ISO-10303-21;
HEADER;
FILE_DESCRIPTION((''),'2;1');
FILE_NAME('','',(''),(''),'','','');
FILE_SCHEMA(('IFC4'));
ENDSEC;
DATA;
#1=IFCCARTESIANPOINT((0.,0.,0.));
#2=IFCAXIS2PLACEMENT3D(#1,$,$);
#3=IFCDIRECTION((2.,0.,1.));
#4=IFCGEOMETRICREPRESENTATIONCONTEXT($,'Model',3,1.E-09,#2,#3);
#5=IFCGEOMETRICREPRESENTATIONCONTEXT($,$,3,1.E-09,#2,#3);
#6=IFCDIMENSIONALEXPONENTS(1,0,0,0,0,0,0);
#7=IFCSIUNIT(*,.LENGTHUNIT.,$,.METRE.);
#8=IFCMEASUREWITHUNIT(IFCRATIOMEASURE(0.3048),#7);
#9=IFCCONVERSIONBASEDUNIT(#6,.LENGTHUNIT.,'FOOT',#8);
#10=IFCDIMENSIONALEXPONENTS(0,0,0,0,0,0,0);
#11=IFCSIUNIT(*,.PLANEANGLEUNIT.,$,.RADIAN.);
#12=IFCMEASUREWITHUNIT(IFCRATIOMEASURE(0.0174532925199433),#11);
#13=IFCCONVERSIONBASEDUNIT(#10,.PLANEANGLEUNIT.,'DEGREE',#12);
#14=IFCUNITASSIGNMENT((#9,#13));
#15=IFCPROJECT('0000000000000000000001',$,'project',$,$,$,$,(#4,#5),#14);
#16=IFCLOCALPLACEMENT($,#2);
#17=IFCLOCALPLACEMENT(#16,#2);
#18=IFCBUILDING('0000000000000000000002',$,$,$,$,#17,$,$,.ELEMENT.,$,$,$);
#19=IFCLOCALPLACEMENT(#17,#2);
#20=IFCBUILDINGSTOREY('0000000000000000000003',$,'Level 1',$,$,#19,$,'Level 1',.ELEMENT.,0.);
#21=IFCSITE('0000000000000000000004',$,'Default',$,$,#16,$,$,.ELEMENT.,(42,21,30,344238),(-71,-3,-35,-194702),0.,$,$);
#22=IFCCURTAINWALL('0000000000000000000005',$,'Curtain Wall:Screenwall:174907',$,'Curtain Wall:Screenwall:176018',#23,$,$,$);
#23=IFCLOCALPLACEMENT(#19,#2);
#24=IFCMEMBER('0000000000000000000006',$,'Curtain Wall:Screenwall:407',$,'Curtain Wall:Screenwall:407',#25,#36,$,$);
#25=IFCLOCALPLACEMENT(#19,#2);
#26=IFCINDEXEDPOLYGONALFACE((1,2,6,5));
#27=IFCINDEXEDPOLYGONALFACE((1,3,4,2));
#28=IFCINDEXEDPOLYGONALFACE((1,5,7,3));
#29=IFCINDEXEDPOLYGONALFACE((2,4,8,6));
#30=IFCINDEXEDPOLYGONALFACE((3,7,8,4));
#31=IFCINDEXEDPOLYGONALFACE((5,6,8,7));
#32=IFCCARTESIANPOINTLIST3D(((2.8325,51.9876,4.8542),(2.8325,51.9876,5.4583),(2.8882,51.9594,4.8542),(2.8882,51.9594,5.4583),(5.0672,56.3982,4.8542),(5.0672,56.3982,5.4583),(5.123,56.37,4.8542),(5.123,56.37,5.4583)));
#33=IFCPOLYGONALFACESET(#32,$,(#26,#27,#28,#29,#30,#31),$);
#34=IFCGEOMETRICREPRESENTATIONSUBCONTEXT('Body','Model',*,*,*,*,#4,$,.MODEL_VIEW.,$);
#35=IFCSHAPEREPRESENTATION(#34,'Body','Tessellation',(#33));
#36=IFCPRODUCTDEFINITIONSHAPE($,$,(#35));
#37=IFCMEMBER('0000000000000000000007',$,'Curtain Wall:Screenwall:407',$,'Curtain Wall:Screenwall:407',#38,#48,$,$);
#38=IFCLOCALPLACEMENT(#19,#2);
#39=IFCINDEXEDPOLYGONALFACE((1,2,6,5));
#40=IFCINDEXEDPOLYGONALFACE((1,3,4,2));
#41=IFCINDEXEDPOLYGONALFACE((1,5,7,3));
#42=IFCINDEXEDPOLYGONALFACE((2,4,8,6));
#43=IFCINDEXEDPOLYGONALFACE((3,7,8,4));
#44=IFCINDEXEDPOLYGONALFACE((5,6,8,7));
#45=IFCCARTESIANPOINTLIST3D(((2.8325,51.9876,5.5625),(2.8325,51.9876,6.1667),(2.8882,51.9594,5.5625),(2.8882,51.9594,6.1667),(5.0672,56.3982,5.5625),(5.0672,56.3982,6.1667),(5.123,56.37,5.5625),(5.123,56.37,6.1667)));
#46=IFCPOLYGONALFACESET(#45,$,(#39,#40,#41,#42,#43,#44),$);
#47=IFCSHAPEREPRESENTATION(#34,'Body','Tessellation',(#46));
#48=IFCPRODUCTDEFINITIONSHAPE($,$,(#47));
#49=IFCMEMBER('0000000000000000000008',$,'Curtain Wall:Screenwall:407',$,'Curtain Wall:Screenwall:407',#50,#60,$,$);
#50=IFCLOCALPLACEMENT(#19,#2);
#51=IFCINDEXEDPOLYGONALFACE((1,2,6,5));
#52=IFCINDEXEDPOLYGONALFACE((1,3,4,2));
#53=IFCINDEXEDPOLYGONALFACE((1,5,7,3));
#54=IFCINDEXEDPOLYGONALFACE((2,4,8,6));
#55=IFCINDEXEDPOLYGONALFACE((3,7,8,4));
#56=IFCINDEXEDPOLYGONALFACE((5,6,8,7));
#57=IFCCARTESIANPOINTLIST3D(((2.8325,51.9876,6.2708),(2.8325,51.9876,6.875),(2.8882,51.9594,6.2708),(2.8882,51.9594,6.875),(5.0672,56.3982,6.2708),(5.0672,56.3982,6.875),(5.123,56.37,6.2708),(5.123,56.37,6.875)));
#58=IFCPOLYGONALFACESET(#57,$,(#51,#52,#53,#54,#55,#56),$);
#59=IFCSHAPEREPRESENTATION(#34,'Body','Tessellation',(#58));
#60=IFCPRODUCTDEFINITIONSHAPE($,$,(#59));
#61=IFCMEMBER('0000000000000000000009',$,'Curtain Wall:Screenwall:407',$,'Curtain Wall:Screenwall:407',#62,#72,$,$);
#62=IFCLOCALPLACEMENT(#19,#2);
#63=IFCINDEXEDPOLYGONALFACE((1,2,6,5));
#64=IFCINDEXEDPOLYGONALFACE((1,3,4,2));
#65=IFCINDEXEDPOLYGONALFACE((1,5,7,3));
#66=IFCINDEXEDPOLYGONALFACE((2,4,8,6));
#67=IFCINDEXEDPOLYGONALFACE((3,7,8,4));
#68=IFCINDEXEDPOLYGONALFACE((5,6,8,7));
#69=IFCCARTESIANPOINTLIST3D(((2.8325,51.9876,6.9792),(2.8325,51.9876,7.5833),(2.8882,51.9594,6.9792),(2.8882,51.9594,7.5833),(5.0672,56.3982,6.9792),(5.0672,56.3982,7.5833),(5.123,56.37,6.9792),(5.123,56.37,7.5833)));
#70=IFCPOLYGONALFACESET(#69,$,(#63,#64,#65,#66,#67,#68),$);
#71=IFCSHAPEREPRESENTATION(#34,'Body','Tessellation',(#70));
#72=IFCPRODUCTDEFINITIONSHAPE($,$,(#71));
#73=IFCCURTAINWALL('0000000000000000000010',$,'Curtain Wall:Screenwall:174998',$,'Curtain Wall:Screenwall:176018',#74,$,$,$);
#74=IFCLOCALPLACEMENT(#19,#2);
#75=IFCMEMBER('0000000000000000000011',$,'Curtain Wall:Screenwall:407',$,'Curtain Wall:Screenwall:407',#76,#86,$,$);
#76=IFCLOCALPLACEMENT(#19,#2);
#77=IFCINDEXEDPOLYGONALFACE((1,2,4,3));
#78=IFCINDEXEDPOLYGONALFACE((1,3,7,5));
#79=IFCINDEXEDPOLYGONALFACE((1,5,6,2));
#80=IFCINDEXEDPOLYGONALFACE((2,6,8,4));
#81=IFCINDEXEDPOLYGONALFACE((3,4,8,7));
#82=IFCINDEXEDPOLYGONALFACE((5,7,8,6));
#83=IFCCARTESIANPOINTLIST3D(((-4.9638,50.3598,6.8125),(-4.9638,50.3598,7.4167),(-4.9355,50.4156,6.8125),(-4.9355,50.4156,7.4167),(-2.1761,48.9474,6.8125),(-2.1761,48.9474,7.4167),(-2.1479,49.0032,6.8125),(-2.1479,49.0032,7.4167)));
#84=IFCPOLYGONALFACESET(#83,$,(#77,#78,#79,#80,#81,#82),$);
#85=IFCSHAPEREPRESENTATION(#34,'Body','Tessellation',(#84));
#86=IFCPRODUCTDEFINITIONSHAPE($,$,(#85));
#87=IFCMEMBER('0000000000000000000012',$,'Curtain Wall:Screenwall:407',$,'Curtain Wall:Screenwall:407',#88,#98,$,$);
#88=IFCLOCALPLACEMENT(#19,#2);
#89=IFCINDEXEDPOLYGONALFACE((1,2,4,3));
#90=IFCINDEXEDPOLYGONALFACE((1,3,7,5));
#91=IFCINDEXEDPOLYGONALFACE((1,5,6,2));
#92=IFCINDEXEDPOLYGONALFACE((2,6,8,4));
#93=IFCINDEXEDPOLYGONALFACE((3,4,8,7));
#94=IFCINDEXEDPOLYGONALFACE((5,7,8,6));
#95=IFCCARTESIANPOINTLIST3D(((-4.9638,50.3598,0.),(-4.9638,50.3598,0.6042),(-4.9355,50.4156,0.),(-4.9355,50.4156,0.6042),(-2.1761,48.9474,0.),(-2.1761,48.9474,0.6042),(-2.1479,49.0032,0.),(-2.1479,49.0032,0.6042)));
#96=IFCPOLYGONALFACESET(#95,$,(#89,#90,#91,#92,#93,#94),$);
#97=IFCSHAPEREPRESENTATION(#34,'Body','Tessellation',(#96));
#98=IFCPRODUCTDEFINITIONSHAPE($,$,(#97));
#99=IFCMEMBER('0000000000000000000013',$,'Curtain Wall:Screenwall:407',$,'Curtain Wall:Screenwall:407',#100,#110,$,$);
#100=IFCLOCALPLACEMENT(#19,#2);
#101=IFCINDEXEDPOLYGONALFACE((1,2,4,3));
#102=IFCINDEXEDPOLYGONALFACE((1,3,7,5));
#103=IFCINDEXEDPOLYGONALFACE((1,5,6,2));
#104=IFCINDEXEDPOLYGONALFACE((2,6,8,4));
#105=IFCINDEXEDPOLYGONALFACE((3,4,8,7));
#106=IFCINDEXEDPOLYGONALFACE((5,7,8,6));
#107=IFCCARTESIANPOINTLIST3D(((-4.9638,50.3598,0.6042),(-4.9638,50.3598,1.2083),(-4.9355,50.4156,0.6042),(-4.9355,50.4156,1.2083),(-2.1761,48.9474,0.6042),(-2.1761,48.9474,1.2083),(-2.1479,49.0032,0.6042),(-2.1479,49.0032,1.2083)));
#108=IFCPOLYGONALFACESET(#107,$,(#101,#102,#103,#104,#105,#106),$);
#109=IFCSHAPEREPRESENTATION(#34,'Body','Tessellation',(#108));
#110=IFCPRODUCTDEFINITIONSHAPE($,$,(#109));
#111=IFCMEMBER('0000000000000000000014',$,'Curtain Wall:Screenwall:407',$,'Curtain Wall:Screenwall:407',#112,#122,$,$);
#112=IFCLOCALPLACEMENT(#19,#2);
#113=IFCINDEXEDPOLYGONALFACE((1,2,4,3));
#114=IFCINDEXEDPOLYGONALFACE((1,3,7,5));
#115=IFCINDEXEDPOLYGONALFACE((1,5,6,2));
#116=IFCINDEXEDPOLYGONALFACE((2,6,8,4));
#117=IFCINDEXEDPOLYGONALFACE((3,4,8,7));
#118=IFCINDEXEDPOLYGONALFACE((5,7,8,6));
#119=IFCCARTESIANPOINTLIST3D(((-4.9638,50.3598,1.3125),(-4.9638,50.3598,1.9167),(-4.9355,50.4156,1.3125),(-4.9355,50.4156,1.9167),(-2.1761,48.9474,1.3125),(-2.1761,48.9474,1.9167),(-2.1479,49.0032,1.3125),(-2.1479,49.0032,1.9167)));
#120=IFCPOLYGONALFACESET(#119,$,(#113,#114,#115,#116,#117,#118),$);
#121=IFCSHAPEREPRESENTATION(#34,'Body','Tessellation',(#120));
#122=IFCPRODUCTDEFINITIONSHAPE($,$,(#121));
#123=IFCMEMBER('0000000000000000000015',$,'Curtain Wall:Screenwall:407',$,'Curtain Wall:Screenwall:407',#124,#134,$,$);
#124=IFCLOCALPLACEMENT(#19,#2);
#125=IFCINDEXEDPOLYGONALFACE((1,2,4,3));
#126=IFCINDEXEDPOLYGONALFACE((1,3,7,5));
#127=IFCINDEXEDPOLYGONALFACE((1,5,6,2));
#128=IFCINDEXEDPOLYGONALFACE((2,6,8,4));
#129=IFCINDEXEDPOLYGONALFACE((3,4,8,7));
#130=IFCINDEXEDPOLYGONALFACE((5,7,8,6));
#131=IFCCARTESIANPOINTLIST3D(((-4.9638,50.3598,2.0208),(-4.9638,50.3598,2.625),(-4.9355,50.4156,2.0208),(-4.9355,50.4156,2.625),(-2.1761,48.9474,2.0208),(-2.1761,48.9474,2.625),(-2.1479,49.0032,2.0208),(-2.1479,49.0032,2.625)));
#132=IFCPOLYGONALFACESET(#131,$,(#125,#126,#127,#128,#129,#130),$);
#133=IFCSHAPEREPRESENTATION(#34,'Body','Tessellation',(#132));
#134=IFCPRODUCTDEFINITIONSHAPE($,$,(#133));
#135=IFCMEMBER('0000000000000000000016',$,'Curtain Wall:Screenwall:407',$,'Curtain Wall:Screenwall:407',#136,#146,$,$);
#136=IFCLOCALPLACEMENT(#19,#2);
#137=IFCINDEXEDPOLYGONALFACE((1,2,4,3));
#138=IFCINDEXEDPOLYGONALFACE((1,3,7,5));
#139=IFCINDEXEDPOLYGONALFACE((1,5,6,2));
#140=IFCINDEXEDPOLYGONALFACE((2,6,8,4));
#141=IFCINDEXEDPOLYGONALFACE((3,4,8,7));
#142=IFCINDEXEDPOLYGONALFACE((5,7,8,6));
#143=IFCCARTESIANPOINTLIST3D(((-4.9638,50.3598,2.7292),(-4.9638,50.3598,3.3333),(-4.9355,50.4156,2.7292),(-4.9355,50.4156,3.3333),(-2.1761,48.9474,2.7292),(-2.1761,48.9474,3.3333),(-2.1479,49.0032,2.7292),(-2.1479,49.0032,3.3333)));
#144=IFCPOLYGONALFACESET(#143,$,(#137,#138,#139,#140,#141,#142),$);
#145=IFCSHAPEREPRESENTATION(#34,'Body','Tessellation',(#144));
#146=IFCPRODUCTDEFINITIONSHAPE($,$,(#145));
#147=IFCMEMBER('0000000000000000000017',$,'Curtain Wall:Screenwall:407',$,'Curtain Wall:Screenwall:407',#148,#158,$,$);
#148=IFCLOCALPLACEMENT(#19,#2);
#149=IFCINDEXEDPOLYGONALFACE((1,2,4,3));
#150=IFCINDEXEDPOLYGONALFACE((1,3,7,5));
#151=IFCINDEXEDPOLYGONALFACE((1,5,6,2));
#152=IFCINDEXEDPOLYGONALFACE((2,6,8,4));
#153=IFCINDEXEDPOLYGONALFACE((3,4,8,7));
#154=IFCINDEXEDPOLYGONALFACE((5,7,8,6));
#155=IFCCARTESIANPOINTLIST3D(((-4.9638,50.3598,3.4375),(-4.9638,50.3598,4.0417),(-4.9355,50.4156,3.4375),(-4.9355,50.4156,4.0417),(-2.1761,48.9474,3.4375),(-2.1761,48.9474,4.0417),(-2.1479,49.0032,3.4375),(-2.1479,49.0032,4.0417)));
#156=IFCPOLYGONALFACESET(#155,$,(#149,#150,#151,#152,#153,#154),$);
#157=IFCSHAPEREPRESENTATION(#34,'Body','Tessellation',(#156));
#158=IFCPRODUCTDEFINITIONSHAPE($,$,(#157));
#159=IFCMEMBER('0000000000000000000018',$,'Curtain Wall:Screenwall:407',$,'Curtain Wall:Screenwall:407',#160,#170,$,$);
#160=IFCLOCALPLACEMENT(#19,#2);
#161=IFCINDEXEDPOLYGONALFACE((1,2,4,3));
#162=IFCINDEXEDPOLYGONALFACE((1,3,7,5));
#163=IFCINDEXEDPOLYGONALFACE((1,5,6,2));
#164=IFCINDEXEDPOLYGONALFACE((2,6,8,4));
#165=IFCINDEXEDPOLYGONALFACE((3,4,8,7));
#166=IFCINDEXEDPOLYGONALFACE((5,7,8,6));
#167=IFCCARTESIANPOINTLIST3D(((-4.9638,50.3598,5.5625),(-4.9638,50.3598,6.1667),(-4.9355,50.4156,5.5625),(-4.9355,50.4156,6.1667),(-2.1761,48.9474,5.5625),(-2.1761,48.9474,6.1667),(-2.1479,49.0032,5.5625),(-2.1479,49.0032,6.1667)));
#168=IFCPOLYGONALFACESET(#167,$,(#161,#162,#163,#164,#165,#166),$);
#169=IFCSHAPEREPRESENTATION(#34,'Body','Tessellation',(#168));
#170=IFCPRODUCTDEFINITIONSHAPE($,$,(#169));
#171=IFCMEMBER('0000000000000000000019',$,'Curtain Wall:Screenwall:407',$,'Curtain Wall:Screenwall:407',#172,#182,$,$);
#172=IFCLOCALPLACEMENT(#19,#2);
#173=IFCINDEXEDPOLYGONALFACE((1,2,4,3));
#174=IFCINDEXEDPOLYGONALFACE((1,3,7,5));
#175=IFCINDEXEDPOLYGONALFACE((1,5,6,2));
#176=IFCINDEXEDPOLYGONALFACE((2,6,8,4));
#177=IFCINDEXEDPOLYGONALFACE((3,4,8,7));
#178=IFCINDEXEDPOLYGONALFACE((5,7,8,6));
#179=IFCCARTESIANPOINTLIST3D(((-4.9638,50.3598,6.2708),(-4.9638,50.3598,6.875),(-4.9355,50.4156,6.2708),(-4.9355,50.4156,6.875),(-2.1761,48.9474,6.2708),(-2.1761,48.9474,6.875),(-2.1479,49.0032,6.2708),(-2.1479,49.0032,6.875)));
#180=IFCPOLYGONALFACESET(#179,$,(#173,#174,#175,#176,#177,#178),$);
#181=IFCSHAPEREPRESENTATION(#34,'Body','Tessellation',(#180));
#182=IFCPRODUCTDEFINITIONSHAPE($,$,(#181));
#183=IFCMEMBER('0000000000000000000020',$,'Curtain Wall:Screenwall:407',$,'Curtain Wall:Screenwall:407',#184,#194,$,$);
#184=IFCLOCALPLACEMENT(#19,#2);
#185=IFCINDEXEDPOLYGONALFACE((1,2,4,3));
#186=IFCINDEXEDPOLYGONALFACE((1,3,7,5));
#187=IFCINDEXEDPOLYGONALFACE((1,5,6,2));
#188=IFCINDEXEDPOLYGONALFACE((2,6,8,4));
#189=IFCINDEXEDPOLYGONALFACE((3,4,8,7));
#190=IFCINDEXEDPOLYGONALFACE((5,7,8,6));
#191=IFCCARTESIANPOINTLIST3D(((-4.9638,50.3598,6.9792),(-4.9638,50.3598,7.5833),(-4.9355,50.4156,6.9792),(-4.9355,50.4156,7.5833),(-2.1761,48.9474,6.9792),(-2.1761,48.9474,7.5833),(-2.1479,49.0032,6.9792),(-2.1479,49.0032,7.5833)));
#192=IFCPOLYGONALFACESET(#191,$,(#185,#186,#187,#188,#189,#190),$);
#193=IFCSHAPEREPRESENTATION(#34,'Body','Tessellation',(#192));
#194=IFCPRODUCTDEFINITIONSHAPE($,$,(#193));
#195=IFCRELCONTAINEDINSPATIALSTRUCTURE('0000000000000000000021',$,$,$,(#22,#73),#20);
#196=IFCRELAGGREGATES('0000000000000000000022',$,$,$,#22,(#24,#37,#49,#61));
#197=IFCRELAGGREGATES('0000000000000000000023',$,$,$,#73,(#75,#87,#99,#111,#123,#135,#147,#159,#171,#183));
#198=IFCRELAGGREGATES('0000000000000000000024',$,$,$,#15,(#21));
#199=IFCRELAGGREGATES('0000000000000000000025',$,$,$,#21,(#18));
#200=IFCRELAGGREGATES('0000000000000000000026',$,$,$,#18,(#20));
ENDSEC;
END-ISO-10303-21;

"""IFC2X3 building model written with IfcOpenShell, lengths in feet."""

from ifc_helpers import new_model, entity, si_unit, converted_unit, direction, frame, frame_2d, origin, origin_2d_with_axis, place, context, subcontext, project, spatial, rectangle, extrude, element, aggregate, save


model = new_model("IFC2X3")

# Units and contexts
model_context = context("Model", 3, precision=1e-09, world=origin(), true_north=direction((2.0, 0.0, 1.0)))
context_of_model = context(None, 3, precision=1e-09, world=origin(), true_north=direction((2.0, 0.0, 1.0)))
body_context = subcontext(model_context, "Body", "Model", "MODEL_VIEW")
ifc_project = project(units=[converted_unit("LENGTHUNIT", "FOOT", entity("IfcRatioMeasure", 0.3048), si_unit("LENGTHUNIT", "METRE"), dimensions=[1, 0, 0, 0, 0, 0, 0]), converted_unit("PLANEANGLEUNIT", "DEGREE", entity("IfcRatioMeasure", 0.0174532925199433), si_unit("PLANEANGLEUNIT", "RADIAN"), dimensions=[0, 0, 0, 0, 0, 0, 0])], contexts=[model_context, context_of_model])

# Site, building, storey
site_placement = place(None, origin())
site = spatial("IfcSite", under=ifc_project, at=site_placement, Name="Default", CompositionType="ELEMENT", RefLatitude=(42, 21, 30, 344238), RefLongitude=(-71, -3, -35, -194702), RefElevation=0.0)
building_placement = place(site_placement, origin())
building = spatial("IfcBuilding", under=site, at=building_placement, CompositionType="ELEMENT")
storey_placement = place(building_placement, origin())
storey = spatial("IfcBuildingStorey", under=building, at=storey_placement, Name="Level 1", LongName="Level 1", CompositionType="ELEMENT", Elevation=0.0)

# Curtain walls, members
curtain_wall_1_placement = place(storey_placement, origin())
curtain_wall_1 = element("IfcCurtainWall", 1, at=curtain_wall_1_placement, inside=storey, Name="Curtain Wall:Screenwall:174907", ObjectType="Curtain Wall:Screenwall:176018")
member_1_placement = place(curtain_wall_1_placement, frame((2.8325, 51.9594, 4.8542)))
member_1 = element("IfcMember", 2, at=member_1_placement, Name="Curtain Wall:Screenwall:407", ObjectType="Curtain Wall:Screenwall:407", context=body_context, shape_type="SweptSolid", body=[
    extrude(rectangle(XDim=4.9444, YDim=0.0625, at=frame_2d((0.0, 0.0), x_axis=(1.0, 0.0))), frame((1.1452, 2.2194, 0.0), z_axis=(0.0, 0.0, 1.0), x_axis=(-0.451968, -0.892034, 0.0)), (0.0, 0.0, 1.0), 0.6042),
])
member_2_placement = place(curtain_wall_1_placement, frame((2.8325, 51.9594, 5.5625)))
member_2 = element("IfcMember", 3, at=member_2_placement, Name="Curtain Wall:Screenwall:407", ObjectType="Curtain Wall:Screenwall:407", context=body_context, shape_type="SweptSolid", body=[
    extrude(rectangle(XDim=4.9444, YDim=0.0625, at=frame_2d((0.0, 0.0), x_axis=(1.0, 0.0))), frame((1.1452, 2.2194, 0.0), z_axis=(0.0, 0.0, 1.0), x_axis=(-0.451968, -0.892034, 0.0)), (0.0, 0.0, 1.0), 0.6042),
])
member_3_placement = place(curtain_wall_1_placement, frame((2.8325, 51.9594, 6.2708)))
member_3 = element("IfcMember", 4, at=member_3_placement, Name="Curtain Wall:Screenwall:407", ObjectType="Curtain Wall:Screenwall:407", context=body_context, shape_type="SweptSolid", body=[
    extrude(rectangle(XDim=4.9444, YDim=0.0625, at=frame_2d((0.0, 0.0), x_axis=(1.0, 0.0))), frame((1.1452, 2.2194, 0.0), z_axis=(0.0, 0.0, 1.0), x_axis=(-0.451968, -0.892034, 0.0)), (0.0, 0.0, 1.0), 0.6042),
])
member_4_placement = place(curtain_wall_1_placement, frame((2.8325, 51.9594, 6.9792)))
member_4 = element("IfcMember", 5, at=member_4_placement, Name="Curtain Wall:Screenwall:407", ObjectType="Curtain Wall:Screenwall:407", context=body_context, shape_type="SweptSolid", body=[
    extrude(rectangle(XDim=4.9444, YDim=0.0625, at=frame_2d((0.0, 0.0), x_axis=(1.0, 0.0))), frame((1.1452, 2.2194, 0.0), z_axis=(0.0, 0.0, 1.0), x_axis=(-0.451968, -0.892034, 0.0)), (0.0, 0.0, 1.0), 0.6042),
])
aggregate(curtain_wall_1, [member_1, member_2, member_3, member_4])
curtain_wall_2_placement = place(storey_placement, origin())
curtain_wall_2 = element("IfcCurtainWall", 6, at=curtain_wall_2_placement, inside=storey, Name="Curtain Wall:Screenwall:174998", ObjectType="Curtain Wall:Screenwall:176018")
member_5_placement = place(curtain_wall_2_placement, frame((-4.9638, 48.9474, 6.8125)))
member_5 = element("IfcMember", 7, at=member_5_placement, Name="Curtain Wall:Screenwall:407", ObjectType="Curtain Wall:Screenwall:407", context=body_context, shape_type="SweptSolid", body=[
    extrude(rectangle(XDim=3.1251, YDim=0.0625, at=origin_2d_with_axis()), frame((1.408, 0.7341, 0.0), z_axis=(0.0, 0.0, 1.0), x_axis=(0.892034, -0.451968, 0.0)), (0.0, 0.0, 1.0), 0.6042),
])
member_6_placement = place(curtain_wall_2_placement, frame((-4.9638, 48.9474, 0.0)))
member_6 = element("IfcMember", 8, at=member_6_placement, Name="Curtain Wall:Screenwall:407", ObjectType="Curtain Wall:Screenwall:407", context=body_context, shape_type="SweptSolid", body=[
    extrude(rectangle(XDim=3.1251, YDim=0.0625, at=frame_2d((0.0, 0.0), x_axis=(1.0, 0.0))), frame((1.408, 0.7341, 0.0), z_axis=(0.0, 0.0, 1.0), x_axis=(-0.892034, 0.451968, 0.0)), (0.0, 0.0, 1.0), 0.6042),
])
member_7_placement = place(curtain_wall_2_placement, frame((-4.9638, 48.9474, 0.6042)))
member_7 = element("IfcMember", 9, at=member_7_placement, Name="Curtain Wall:Screenwall:407", ObjectType="Curtain Wall:Screenwall:407", context=body_context, shape_type="SweptSolid", body=[
    extrude(rectangle(XDim=3.1251, YDim=0.0625, at=frame_2d((0.0, 0.0), x_axis=(1.0, 0.0))), frame((1.408, 0.7341, 0.0), z_axis=(0.0, 0.0, 1.0), x_axis=(0.892034, -0.451968, 0.0)), (0.0, 0.0, 1.0), 0.6042),
])
member_8_placement = place(curtain_wall_2_placement, frame((-4.9638, 48.9474, 1.3125)))
member_8 = element("IfcMember", 10, at=member_8_placement, Name="Curtain Wall:Screenwall:407", ObjectType="Curtain Wall:Screenwall:407", context=body_context, shape_type="SweptSolid", body=[
    extrude(rectangle(XDim=3.1251, YDim=0.0625, at=frame_2d((0.0, 0.0), x_axis=(1.0, 0.0))), frame((1.408, 0.7341, 0.0), z_axis=(0.0, 0.0, 1.0), x_axis=(0.892034, -0.451968, 0.0)), (0.0, 0.0, 1.0), 0.6042),
])
member_9_placement = place(curtain_wall_2_placement, frame((-4.9638, 48.9474, 2.0208)))
member_9 = element("IfcMember", 11, at=member_9_placement, Name="Curtain Wall:Screenwall:407", ObjectType="Curtain Wall:Screenwall:407", context=body_context, shape_type="SweptSolid", body=[
    extrude(rectangle(XDim=3.1251, YDim=0.0625, at=frame_2d((0.0, 0.0), x_axis=(1.0, 0.0))), frame((1.408, 0.7341, 0.0), z_axis=(0.0, 0.0, 1.0), x_axis=(0.892034, -0.451968, 0.0)), (0.0, 0.0, 1.0), 0.6042),
])
member_10_placement = place(curtain_wall_2_placement, frame((-4.9638, 48.9474, 2.7292)))
member_10 = element("IfcMember", 12, at=member_10_placement, Name="Curtain Wall:Screenwall:407", ObjectType="Curtain Wall:Screenwall:407", context=body_context, shape_type="SweptSolid", body=[
    extrude(rectangle(XDim=3.1251, YDim=0.0625, at=frame_2d((0.0, 0.0), x_axis=(1.0, 0.0))), frame((1.408, 0.7341, 0.0), z_axis=(0.0, 0.0, 1.0), x_axis=(0.892034, -0.451968, 0.0)), (0.0, 0.0, 1.0), 0.6042),
])
member_11_placement = place(curtain_wall_2_placement, frame((-4.9638, 48.9474, 3.4375)))
member_11 = element("IfcMember", 13, at=member_11_placement, Name="Curtain Wall:Screenwall:407", ObjectType="Curtain Wall:Screenwall:407", context=body_context, shape_type="SweptSolid", body=[
    extrude(rectangle(XDim=3.1251, YDim=0.0625, at=frame_2d((0.0, 0.0), x_axis=(1.0, 0.0))), frame((1.408, 0.7341, 0.0), z_axis=(0.0, 0.0, 1.0), x_axis=(0.892034, -0.451968, 0.0)), (0.0, 0.0, 1.0), 0.6042),
])
member_12_placement = place(curtain_wall_2_placement, frame((-4.9638, 48.9474, 5.5625)))
member_12 = element("IfcMember", 14, at=member_12_placement, Name="Curtain Wall:Screenwall:407", ObjectType="Curtain Wall:Screenwall:407", context=body_context, shape_type="SweptSolid", body=[
    extrude(rectangle(XDim=3.1251, YDim=0.0625, at=frame_2d((0.0, 0.0), x_axis=(1.0, 0.0))), frame((1.408, 0.7341, 0.0), z_axis=(0.0, 0.0, 1.0), x_axis=(0.892034, -0.451968, 0.0)), (0.0, 0.0, 1.0), 0.6042),
])
member_13_placement = place(curtain_wall_2_placement, frame((-4.9638, 48.9474, 6.2708)))
member_13 = element("IfcMember", 15, at=member_13_placement, Name="Curtain Wall:Screenwall:407", ObjectType="Curtain Wall:Screenwall:407", context=body_context, shape_type="SweptSolid", body=[
    extrude(rectangle(XDim=3.1251, YDim=0.0625, at=frame_2d((0.0, 0.0), x_axis=(1.0, 0.0))), frame((1.408, 0.7341, 0.0), z_axis=(0.0, 0.0, 1.0), x_axis=(0.892034, -0.451968, 0.0)), (0.0, 0.0, 1.0), 0.6042),
])
member_14_placement = place(curtain_wall_2_placement, frame((-4.9638, 48.9474, 6.9792)))
member_14 = element("IfcMember", 16, at=member_14_placement, Name="Curtain Wall:Screenwall:407", ObjectType="Curtain Wall:Screenwall:407", context=body_context, shape_type="SweptSolid", body=[
    extrude(rectangle(XDim=3.1251, YDim=0.0625, at=frame_2d((0.0, 0.0), x_axis=(1.0, 0.0))), frame((1.408, 0.7341, 0.0), z_axis=(0.0, 0.0, 1.0), x_axis=(0.892034, -0.451968, 0.0)), (0.0, 0.0, 1.0), 0.6042),
])
aggregate(curtain_wall_2, [member_5, member_6, member_7, member_8, member_9, member_10, member_11, member_12, member_13, member_14])

save(model, "model.ifc")
